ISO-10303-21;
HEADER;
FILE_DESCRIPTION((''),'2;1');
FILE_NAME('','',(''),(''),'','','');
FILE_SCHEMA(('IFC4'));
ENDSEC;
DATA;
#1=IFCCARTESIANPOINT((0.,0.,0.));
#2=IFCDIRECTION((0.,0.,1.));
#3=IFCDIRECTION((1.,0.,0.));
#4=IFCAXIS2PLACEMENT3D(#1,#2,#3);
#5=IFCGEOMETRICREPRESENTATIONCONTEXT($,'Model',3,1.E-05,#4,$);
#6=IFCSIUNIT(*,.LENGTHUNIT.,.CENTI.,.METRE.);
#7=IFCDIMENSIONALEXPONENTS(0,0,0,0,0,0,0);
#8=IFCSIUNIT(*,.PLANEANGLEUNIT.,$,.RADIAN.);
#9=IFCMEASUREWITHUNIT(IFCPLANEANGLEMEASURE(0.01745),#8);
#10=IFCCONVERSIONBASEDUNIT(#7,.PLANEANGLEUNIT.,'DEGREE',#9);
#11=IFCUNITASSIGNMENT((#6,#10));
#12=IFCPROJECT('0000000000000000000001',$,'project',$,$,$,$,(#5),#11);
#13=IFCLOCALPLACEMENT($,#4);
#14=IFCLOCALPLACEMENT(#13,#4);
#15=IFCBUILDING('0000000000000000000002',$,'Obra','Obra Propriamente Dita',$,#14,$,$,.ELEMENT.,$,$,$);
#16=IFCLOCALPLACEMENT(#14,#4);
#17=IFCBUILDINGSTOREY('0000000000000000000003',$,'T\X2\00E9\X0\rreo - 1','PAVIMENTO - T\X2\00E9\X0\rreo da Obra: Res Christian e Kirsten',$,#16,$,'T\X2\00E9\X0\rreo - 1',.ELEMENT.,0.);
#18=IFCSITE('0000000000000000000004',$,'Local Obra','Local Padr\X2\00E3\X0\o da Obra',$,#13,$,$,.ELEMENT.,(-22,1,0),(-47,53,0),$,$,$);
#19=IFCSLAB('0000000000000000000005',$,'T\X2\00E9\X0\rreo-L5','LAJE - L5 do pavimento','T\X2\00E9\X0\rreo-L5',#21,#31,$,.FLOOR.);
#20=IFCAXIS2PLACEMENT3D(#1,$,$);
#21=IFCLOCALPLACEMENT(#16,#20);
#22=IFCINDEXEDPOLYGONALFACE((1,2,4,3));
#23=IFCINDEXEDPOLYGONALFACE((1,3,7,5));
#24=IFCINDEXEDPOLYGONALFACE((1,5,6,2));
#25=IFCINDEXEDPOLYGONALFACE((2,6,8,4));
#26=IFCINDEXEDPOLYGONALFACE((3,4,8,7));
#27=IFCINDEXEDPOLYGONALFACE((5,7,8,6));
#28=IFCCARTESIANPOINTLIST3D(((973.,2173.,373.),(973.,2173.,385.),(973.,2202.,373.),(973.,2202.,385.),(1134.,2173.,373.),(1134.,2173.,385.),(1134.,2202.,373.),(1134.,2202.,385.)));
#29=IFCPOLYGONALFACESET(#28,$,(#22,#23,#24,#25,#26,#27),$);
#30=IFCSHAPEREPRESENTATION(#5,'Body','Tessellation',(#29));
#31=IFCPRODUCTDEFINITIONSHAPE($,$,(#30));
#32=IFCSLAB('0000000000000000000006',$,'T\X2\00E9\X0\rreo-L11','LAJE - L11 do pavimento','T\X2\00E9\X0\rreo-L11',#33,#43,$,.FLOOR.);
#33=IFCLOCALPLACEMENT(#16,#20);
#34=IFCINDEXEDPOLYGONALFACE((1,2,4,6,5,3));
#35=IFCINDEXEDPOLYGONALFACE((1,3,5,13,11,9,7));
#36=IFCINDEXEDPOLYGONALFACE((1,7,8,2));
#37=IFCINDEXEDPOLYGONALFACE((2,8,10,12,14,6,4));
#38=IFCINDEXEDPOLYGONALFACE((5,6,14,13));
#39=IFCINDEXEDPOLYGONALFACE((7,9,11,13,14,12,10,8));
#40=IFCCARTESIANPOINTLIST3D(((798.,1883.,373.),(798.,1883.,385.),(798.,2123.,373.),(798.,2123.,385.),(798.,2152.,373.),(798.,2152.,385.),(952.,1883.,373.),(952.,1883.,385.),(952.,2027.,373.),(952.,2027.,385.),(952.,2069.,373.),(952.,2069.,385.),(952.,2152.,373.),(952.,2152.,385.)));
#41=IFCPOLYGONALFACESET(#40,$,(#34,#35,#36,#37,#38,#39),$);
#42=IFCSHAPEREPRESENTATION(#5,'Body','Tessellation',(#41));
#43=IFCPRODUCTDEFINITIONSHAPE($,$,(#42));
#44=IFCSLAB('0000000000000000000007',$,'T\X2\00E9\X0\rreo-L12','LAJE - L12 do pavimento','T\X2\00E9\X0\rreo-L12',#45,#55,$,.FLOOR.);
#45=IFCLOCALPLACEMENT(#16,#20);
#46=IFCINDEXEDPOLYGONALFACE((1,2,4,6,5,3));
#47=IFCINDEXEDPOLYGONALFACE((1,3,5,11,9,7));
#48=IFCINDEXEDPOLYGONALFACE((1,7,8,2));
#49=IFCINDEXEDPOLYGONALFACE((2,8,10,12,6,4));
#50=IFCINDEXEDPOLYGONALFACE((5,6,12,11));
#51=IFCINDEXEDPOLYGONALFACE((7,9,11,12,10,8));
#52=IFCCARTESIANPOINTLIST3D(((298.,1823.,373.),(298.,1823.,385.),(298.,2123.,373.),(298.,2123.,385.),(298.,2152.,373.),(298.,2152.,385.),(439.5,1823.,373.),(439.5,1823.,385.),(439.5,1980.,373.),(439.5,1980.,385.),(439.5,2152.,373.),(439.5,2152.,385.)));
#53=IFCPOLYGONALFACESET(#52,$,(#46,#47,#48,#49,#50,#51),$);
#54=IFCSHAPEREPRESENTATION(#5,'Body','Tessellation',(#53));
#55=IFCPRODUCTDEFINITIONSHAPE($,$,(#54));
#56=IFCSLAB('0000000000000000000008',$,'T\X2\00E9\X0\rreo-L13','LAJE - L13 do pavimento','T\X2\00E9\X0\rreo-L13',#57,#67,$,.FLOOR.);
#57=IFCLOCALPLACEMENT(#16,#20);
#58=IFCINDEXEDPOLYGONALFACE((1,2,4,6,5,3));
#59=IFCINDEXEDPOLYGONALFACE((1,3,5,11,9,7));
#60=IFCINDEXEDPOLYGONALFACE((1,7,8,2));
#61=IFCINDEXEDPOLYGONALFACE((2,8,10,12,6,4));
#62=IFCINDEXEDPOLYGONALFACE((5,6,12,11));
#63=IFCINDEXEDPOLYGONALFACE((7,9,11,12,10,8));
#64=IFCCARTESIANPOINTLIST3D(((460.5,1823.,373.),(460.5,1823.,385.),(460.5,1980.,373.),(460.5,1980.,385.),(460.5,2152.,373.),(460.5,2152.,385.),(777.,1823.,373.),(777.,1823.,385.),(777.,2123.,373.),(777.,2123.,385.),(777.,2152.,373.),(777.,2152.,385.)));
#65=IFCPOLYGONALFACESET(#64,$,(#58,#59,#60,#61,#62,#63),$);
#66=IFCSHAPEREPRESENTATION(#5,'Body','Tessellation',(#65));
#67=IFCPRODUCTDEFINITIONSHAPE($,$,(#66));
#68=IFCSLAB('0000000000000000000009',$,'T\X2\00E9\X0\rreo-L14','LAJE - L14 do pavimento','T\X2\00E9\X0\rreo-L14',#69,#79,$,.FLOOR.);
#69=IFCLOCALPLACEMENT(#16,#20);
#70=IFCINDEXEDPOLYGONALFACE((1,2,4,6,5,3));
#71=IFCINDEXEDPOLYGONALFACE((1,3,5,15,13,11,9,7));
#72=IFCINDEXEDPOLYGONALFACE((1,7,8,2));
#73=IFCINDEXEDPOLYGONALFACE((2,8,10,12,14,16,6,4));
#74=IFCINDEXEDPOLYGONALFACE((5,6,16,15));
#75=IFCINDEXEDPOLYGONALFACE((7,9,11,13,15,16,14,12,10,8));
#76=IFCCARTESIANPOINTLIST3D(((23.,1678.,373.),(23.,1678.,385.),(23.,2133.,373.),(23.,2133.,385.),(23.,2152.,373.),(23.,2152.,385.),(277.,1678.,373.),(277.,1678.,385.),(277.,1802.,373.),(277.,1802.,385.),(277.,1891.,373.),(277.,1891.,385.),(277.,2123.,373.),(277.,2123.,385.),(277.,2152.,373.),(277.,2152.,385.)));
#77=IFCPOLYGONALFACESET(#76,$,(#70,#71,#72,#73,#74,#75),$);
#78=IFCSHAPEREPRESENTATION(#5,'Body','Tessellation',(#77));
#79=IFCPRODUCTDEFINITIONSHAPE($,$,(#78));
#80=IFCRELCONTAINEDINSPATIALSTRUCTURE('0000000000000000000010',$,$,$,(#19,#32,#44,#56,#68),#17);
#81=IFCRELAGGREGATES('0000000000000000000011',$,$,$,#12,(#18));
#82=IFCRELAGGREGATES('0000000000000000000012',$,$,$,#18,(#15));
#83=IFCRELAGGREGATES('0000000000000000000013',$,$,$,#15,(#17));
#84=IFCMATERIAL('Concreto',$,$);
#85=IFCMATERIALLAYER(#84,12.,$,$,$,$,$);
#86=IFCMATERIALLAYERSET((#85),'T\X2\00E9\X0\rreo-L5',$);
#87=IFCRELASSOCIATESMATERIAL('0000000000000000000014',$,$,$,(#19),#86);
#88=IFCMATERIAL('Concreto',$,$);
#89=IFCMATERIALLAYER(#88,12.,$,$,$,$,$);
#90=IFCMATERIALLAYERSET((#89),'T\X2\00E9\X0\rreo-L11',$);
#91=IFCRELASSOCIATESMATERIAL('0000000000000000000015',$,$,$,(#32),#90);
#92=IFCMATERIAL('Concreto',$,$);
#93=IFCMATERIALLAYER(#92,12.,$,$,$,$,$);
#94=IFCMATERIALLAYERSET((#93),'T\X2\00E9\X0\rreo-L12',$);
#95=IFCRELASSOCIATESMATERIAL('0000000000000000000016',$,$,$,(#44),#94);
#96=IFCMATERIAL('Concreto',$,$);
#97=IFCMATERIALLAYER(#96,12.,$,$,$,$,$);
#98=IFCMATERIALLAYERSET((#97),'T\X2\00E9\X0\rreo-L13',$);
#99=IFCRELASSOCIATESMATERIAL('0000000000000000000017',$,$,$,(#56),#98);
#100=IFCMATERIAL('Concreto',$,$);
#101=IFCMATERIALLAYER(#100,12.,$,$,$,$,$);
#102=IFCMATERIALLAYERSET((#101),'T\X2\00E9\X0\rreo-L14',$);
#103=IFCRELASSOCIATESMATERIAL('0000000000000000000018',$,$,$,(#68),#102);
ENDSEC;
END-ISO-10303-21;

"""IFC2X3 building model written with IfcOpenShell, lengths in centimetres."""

from ifc_helpers import new_model, entity, si_unit, converted_unit, frame, origin_with_axes, place, context, project, spatial, polyline, outline, extrude, material, layer, layer_set, layer_usage, element, save


model = new_model("IFC2X3")

# Units and contexts
model_context = context("Model", 3, precision=1e-05, world=origin_with_axes())
ifc_project = project(units=[si_unit("LENGTHUNIT", "METRE", prefix="CENTI"), converted_unit("PLANEANGLEUNIT", "DEGREE", entity("IfcPlaneAngleMeasure", 0.01745), si_unit("PLANEANGLEUNIT", "RADIAN"), dimensions=[0, 0, 0, 0, 0, 0, 0])], contexts=[model_context])

# Site, building, storey
site_placement = place(None, origin_with_axes())
site = spatial("IfcSite", under=ifc_project, at=site_placement, Name="Local Obra", Description="Local Padrão da Obra", CompositionType="ELEMENT", RefLatitude=(-22, 1, 0), RefLongitude=(-47, 53, 0))
building_placement = place(site_placement, origin_with_axes())
building = spatial("IfcBuilding", under=site, at=building_placement, Name="Obra", Description="Obra Propriamente Dita", CompositionType="ELEMENT")
storey_placement = place(building_placement, origin_with_axes())
storey = spatial("IfcBuildingStorey", under=building, at=storey_placement, Name="Térreo - 1", Description="PAVIMENTO - Térreo da Obra: Res Christian e Kirsten", LongName="Térreo - 1", CompositionType="ELEMENT", Elevation=0.0)

# Slabs
ifc_material_1 = material(Name="Concreto")
ifc_layer_1 = layer(ifc_material_1, 12.0)
ifc_layer_set_1 = layer_set([ifc_layer_1], Name="Térreo-L5")
ifc_layer_usage_1 = layer_usage(ifc_layer_set_1, "AXIS3", "POSITIVE", 0.0)
slab_1_placement = place(storey_placement, frame((973.0, 2173.0, 373.0), z_axis=(0.0, 0.0, 1.0), x_axis=(1.0, 0.0, 0.0)))
element("IfcSlab", 1, at=slab_1_placement, inside=storey, material=ifc_layer_usage_1, Name="Térreo-L5", Description="LAJE - L5 do pavimento", ObjectType="Térreo-L5", PredefinedType="FLOOR", context=model_context, shape_type="SweptSolid", body=[
    extrude(outline(polyline([(161.0, 0.0), (161.0, 29.0), (0.0, 29.0), (0.0, 0.0), (161.0, 0.0)])), origin_with_axes(), (0.0, 0.0, 1.0), 12.0),
])
ifc_material_2 = material(Name="Concreto")
ifc_layer_2 = layer(ifc_material_2, 12.0)
ifc_layer_set_2 = layer_set([ifc_layer_2], Name="Térreo-L11")
ifc_layer_usage_2 = layer_usage(ifc_layer_set_2, "AXIS3", "POSITIVE", 0.0)
slab_2_placement = place(storey_placement, frame((952.0, 2069.0, 373.0), z_axis=(0.0, 0.0, 1.0), x_axis=(1.0, 0.0, 0.0)))
element("IfcSlab", 2, at=slab_2_placement, inside=storey, material=ifc_layer_usage_2, Name="Térreo-L11", Description="LAJE - L11 do pavimento", ObjectType="Térreo-L11", PredefinedType="FLOOR", context=model_context, shape_type="SweptSolid", body=[
    extrude(outline(polyline([(0.0, 83.0), (-154.0, 83.0), (-154.0, 54.0), (-154.0, -186.0), (0.0, -186.0), (0.0, -42.0), (0.0, 0.0), (0.0, 83.0)])), origin_with_axes(), (0.0, 0.0, 1.0), 12.0),
])
ifc_material_3 = material(Name="Concreto")
ifc_layer_3 = layer(ifc_material_3, 12.0)
ifc_layer_set_3 = layer_set([ifc_layer_3], Name="Térreo-L12")
ifc_layer_usage_3 = layer_usage(ifc_layer_set_3, "AXIS3", "POSITIVE", 0.0)
slab_3_placement = place(storey_placement, frame((439.5, 1980.0, 373.0), z_axis=(0.0, 0.0, 1.0), x_axis=(1.0, 0.0, 0.0)))
element("IfcSlab", 3, at=slab_3_placement, inside=storey, material=ifc_layer_usage_3, Name="Térreo-L12", Description="LAJE - L12 do pavimento", ObjectType="Térreo-L12", PredefinedType="FLOOR", context=model_context, shape_type="SweptSolid", body=[
    extrude(outline(polyline([(0.0, 172.0), (-141.5, 172.0), (-141.5, 143.0), (-141.5, -157.0), (0.0, -157.0), (0.0, 0.0), (0.0, 172.0)])), origin_with_axes(), (0.0, 0.0, 1.0), 12.0),
])
ifc_material_4 = material(Name="Concreto")
ifc_layer_4 = layer(ifc_material_4, 12.0)
ifc_layer_set_4 = layer_set([ifc_layer_4], Name="Térreo-L13")
ifc_layer_usage_4 = layer_usage(ifc_layer_set_4, "AXIS3", "POSITIVE", 0.0)
slab_4_placement = place(storey_placement, frame((777.0, 2123.0, 373.0), z_axis=(0.0, 0.0, 1.0), x_axis=(1.0, 0.0, 0.0)))
element("IfcSlab", 4, at=slab_4_placement, inside=storey, material=ifc_layer_usage_4, Name="Térreo-L13", Description="LAJE - L13 do pavimento", ObjectType="Térreo-L13", PredefinedType="FLOOR", context=model_context, shape_type="SweptSolid", body=[
    extrude(outline(polyline([(0.0, 29.0), (-316.5, 29.0), (-316.5, -143.0), (-316.5, -300.0), (0.0, -300.0), (0.0, 0.0), (0.0, 29.0)])), origin_with_axes(), (0.0, 0.0, 1.0), 12.0),
])
ifc_material_5 = material(Name="Concreto")
ifc_layer_5 = layer(ifc_material_5, 12.0)
ifc_layer_set_5 = layer_set([ifc_layer_5], Name="Térreo-L14")
ifc_layer_usage_5 = layer_usage(ifc_layer_set_5, "AXIS3", "POSITIVE", 0.0)
slab_5_placement = place(storey_placement, frame((277.0, 2123.0, 373.0), z_axis=(0.0, 0.0, 1.0), x_axis=(1.0, 0.0, 0.0)))
element("IfcSlab", 5, at=slab_5_placement, inside=storey, material=ifc_layer_usage_5, Name="Térreo-L14", Description="LAJE - L14 do pavimento", ObjectType="Térreo-L14", PredefinedType="FLOOR", context=model_context, shape_type="SweptSolid", body=[
    extrude(outline(polyline([(0.0, 29.0), (-254.0, 29.0), (-254.0, 10.0), (-254.0, -445.0), (0.0, -445.0), (0.0, -321.0), (0.0, -232.0), (0.0, 0.0), (0.0, 29.0)])), origin_with_axes(), (0.0, 0.0, 1.0), 12.0),
])

save(model, "model.ifc")
